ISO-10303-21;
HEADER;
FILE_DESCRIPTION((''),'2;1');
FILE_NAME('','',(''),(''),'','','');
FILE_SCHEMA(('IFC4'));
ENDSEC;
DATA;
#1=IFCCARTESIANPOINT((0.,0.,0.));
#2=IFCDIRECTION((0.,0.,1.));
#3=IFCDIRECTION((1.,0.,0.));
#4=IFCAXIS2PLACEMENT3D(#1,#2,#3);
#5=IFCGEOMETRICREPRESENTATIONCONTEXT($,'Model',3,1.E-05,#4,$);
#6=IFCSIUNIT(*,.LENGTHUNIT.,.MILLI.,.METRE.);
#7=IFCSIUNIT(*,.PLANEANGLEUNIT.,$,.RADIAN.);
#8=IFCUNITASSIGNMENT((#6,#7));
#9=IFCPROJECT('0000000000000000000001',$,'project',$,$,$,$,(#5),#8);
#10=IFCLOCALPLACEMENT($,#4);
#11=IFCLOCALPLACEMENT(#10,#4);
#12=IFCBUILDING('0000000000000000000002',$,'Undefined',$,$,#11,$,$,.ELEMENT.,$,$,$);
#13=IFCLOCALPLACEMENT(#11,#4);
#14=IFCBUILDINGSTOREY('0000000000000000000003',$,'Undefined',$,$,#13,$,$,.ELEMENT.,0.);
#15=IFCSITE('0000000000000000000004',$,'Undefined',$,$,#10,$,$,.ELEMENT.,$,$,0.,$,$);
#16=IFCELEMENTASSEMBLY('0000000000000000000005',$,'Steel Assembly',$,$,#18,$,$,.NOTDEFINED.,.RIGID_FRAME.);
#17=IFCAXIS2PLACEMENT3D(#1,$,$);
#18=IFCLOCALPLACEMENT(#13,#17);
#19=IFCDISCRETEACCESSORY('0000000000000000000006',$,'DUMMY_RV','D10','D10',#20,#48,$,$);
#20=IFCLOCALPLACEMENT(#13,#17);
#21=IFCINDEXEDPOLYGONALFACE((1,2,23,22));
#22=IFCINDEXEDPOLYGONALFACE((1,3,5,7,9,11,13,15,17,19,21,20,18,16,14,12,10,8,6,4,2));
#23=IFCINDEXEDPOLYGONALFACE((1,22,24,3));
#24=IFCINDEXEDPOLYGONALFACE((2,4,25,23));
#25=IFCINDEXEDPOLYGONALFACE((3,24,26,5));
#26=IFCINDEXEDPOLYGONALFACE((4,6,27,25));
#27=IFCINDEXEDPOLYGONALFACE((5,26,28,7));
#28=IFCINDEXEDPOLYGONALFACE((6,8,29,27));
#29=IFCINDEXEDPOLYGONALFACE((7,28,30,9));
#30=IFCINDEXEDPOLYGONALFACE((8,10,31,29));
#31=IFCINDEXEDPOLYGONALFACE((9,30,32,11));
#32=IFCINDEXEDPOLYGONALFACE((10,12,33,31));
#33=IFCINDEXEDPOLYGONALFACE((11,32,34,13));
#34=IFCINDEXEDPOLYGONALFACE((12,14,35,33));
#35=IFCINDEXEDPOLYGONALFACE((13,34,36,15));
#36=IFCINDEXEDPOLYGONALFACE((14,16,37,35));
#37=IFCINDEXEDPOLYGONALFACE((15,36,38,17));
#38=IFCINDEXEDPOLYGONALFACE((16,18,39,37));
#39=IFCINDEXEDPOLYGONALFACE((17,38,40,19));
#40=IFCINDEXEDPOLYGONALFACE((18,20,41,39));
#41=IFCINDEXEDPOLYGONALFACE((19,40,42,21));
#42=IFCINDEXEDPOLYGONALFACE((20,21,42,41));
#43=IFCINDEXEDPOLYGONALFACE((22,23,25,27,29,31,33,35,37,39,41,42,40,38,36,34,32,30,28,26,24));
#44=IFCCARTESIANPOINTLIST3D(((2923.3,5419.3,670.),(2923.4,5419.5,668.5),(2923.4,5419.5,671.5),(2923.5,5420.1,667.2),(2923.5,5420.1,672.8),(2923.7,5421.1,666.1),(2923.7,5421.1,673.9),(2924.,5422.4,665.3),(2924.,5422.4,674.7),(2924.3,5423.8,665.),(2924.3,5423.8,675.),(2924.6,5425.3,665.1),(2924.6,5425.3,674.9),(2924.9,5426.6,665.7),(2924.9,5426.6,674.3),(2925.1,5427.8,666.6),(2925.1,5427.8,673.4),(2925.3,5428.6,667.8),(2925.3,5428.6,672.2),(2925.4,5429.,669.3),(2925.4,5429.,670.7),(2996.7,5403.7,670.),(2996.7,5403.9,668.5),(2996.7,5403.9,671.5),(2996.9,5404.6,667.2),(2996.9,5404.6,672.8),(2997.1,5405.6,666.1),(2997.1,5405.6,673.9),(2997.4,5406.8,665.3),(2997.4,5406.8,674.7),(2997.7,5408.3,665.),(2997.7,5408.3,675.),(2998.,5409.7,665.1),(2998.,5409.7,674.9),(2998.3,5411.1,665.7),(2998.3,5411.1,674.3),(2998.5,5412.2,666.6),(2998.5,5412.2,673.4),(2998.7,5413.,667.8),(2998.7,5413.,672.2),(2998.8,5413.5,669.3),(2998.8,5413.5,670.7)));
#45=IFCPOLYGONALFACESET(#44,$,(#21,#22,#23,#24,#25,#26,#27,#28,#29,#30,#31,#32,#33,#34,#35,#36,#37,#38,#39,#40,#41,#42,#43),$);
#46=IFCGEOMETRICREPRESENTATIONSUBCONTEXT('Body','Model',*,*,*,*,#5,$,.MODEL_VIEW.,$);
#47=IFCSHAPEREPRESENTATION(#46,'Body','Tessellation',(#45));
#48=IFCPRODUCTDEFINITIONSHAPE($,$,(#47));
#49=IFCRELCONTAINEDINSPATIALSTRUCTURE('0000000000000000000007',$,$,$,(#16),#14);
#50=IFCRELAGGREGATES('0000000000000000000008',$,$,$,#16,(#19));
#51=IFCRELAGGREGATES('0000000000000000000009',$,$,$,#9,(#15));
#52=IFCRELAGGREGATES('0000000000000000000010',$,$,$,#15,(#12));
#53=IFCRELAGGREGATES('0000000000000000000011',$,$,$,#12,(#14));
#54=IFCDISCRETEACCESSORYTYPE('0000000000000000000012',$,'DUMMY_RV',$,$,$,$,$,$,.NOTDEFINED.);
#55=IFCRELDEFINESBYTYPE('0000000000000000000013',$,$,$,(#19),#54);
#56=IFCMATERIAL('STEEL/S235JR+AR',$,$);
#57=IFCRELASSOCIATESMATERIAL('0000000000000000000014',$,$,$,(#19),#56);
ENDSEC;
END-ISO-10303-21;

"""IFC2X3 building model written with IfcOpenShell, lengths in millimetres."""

from ifc_helpers import new_model, si_unit, frame, origin_with_axes, origin_2d_with_axis, place, context, subcontext, project, spatial, circle, extrude, material, type_object, element, aggregate, save


model = new_model("IFC2X3")

# Units and contexts
model_context = context("Model", 3, precision=1e-05, world=origin_with_axes())
body_context = subcontext(model_context, "Body", "Model", "MODEL_VIEW")
ifc_project = project(units=[si_unit("LENGTHUNIT", "METRE", prefix="MILLI"), si_unit("PLANEANGLEUNIT", "RADIAN")], contexts=[model_context])

# Site, building, storey
site_placement = place(None, origin_with_axes())
site = spatial("IfcSite", under=ifc_project, at=site_placement, Name="Undefined", CompositionType="ELEMENT", RefElevation=0.0)
building_placement = place(site_placement, origin_with_axes())
building = spatial("IfcBuilding", under=site, at=building_placement, Name="Undefined", CompositionType="ELEMENT")
storey_placement = place(building_placement, origin_with_axes())
storey = spatial("IfcBuildingStorey", under=building, at=storey_placement, Name="Undefined", CompositionType="ELEMENT", Elevation=0.0)

# Element assembly
ifc_material_1 = material(Name="STEEL/S235JR+AR")
assembly_1_placement = place(storey_placement, origin_with_axes())
assembly_1 = element("IfcElementAssembly", 1, at=assembly_1_placement, inside=storey, Name="Steel Assembly", AssemblyPlace="NOTDEFINED", PredefinedType="RIGID_FRAME")

# Discrete accessory
discrete_accessory_type = type_object("IfcDiscreteAccessoryType", Name="DUMMY_RV")
discrete_accessory_1_placement = place(assembly_1_placement, frame((2924.4, 5424.2, 670.0), z_axis=(0.0, 0.0, 1.0), x_axis=(0.97824, -0.207475, 0.0)))
discrete_accessory_1 = element("IfcDiscreteAccessory", 2, at=discrete_accessory_1_placement, type_object=discrete_accessory_type, material=ifc_material_1, Name="DUMMY_RV", Description="D10", ObjectType="D10", context=body_context, shape_type="SweptSolid", body=[
    extrude(circle(Radius=5.0, at=origin_2d_with_axis()), frame((75.0, 0.0, 0.0), z_axis=(-1.0, 0.0, 0.0), x_axis=(0.0, -1.0, 0.0)), (0.0, 0.0, 1.0), 75.0),
])
aggregate(assembly_1, [discrete_accessory_1])

save(model, "model.ifc")
